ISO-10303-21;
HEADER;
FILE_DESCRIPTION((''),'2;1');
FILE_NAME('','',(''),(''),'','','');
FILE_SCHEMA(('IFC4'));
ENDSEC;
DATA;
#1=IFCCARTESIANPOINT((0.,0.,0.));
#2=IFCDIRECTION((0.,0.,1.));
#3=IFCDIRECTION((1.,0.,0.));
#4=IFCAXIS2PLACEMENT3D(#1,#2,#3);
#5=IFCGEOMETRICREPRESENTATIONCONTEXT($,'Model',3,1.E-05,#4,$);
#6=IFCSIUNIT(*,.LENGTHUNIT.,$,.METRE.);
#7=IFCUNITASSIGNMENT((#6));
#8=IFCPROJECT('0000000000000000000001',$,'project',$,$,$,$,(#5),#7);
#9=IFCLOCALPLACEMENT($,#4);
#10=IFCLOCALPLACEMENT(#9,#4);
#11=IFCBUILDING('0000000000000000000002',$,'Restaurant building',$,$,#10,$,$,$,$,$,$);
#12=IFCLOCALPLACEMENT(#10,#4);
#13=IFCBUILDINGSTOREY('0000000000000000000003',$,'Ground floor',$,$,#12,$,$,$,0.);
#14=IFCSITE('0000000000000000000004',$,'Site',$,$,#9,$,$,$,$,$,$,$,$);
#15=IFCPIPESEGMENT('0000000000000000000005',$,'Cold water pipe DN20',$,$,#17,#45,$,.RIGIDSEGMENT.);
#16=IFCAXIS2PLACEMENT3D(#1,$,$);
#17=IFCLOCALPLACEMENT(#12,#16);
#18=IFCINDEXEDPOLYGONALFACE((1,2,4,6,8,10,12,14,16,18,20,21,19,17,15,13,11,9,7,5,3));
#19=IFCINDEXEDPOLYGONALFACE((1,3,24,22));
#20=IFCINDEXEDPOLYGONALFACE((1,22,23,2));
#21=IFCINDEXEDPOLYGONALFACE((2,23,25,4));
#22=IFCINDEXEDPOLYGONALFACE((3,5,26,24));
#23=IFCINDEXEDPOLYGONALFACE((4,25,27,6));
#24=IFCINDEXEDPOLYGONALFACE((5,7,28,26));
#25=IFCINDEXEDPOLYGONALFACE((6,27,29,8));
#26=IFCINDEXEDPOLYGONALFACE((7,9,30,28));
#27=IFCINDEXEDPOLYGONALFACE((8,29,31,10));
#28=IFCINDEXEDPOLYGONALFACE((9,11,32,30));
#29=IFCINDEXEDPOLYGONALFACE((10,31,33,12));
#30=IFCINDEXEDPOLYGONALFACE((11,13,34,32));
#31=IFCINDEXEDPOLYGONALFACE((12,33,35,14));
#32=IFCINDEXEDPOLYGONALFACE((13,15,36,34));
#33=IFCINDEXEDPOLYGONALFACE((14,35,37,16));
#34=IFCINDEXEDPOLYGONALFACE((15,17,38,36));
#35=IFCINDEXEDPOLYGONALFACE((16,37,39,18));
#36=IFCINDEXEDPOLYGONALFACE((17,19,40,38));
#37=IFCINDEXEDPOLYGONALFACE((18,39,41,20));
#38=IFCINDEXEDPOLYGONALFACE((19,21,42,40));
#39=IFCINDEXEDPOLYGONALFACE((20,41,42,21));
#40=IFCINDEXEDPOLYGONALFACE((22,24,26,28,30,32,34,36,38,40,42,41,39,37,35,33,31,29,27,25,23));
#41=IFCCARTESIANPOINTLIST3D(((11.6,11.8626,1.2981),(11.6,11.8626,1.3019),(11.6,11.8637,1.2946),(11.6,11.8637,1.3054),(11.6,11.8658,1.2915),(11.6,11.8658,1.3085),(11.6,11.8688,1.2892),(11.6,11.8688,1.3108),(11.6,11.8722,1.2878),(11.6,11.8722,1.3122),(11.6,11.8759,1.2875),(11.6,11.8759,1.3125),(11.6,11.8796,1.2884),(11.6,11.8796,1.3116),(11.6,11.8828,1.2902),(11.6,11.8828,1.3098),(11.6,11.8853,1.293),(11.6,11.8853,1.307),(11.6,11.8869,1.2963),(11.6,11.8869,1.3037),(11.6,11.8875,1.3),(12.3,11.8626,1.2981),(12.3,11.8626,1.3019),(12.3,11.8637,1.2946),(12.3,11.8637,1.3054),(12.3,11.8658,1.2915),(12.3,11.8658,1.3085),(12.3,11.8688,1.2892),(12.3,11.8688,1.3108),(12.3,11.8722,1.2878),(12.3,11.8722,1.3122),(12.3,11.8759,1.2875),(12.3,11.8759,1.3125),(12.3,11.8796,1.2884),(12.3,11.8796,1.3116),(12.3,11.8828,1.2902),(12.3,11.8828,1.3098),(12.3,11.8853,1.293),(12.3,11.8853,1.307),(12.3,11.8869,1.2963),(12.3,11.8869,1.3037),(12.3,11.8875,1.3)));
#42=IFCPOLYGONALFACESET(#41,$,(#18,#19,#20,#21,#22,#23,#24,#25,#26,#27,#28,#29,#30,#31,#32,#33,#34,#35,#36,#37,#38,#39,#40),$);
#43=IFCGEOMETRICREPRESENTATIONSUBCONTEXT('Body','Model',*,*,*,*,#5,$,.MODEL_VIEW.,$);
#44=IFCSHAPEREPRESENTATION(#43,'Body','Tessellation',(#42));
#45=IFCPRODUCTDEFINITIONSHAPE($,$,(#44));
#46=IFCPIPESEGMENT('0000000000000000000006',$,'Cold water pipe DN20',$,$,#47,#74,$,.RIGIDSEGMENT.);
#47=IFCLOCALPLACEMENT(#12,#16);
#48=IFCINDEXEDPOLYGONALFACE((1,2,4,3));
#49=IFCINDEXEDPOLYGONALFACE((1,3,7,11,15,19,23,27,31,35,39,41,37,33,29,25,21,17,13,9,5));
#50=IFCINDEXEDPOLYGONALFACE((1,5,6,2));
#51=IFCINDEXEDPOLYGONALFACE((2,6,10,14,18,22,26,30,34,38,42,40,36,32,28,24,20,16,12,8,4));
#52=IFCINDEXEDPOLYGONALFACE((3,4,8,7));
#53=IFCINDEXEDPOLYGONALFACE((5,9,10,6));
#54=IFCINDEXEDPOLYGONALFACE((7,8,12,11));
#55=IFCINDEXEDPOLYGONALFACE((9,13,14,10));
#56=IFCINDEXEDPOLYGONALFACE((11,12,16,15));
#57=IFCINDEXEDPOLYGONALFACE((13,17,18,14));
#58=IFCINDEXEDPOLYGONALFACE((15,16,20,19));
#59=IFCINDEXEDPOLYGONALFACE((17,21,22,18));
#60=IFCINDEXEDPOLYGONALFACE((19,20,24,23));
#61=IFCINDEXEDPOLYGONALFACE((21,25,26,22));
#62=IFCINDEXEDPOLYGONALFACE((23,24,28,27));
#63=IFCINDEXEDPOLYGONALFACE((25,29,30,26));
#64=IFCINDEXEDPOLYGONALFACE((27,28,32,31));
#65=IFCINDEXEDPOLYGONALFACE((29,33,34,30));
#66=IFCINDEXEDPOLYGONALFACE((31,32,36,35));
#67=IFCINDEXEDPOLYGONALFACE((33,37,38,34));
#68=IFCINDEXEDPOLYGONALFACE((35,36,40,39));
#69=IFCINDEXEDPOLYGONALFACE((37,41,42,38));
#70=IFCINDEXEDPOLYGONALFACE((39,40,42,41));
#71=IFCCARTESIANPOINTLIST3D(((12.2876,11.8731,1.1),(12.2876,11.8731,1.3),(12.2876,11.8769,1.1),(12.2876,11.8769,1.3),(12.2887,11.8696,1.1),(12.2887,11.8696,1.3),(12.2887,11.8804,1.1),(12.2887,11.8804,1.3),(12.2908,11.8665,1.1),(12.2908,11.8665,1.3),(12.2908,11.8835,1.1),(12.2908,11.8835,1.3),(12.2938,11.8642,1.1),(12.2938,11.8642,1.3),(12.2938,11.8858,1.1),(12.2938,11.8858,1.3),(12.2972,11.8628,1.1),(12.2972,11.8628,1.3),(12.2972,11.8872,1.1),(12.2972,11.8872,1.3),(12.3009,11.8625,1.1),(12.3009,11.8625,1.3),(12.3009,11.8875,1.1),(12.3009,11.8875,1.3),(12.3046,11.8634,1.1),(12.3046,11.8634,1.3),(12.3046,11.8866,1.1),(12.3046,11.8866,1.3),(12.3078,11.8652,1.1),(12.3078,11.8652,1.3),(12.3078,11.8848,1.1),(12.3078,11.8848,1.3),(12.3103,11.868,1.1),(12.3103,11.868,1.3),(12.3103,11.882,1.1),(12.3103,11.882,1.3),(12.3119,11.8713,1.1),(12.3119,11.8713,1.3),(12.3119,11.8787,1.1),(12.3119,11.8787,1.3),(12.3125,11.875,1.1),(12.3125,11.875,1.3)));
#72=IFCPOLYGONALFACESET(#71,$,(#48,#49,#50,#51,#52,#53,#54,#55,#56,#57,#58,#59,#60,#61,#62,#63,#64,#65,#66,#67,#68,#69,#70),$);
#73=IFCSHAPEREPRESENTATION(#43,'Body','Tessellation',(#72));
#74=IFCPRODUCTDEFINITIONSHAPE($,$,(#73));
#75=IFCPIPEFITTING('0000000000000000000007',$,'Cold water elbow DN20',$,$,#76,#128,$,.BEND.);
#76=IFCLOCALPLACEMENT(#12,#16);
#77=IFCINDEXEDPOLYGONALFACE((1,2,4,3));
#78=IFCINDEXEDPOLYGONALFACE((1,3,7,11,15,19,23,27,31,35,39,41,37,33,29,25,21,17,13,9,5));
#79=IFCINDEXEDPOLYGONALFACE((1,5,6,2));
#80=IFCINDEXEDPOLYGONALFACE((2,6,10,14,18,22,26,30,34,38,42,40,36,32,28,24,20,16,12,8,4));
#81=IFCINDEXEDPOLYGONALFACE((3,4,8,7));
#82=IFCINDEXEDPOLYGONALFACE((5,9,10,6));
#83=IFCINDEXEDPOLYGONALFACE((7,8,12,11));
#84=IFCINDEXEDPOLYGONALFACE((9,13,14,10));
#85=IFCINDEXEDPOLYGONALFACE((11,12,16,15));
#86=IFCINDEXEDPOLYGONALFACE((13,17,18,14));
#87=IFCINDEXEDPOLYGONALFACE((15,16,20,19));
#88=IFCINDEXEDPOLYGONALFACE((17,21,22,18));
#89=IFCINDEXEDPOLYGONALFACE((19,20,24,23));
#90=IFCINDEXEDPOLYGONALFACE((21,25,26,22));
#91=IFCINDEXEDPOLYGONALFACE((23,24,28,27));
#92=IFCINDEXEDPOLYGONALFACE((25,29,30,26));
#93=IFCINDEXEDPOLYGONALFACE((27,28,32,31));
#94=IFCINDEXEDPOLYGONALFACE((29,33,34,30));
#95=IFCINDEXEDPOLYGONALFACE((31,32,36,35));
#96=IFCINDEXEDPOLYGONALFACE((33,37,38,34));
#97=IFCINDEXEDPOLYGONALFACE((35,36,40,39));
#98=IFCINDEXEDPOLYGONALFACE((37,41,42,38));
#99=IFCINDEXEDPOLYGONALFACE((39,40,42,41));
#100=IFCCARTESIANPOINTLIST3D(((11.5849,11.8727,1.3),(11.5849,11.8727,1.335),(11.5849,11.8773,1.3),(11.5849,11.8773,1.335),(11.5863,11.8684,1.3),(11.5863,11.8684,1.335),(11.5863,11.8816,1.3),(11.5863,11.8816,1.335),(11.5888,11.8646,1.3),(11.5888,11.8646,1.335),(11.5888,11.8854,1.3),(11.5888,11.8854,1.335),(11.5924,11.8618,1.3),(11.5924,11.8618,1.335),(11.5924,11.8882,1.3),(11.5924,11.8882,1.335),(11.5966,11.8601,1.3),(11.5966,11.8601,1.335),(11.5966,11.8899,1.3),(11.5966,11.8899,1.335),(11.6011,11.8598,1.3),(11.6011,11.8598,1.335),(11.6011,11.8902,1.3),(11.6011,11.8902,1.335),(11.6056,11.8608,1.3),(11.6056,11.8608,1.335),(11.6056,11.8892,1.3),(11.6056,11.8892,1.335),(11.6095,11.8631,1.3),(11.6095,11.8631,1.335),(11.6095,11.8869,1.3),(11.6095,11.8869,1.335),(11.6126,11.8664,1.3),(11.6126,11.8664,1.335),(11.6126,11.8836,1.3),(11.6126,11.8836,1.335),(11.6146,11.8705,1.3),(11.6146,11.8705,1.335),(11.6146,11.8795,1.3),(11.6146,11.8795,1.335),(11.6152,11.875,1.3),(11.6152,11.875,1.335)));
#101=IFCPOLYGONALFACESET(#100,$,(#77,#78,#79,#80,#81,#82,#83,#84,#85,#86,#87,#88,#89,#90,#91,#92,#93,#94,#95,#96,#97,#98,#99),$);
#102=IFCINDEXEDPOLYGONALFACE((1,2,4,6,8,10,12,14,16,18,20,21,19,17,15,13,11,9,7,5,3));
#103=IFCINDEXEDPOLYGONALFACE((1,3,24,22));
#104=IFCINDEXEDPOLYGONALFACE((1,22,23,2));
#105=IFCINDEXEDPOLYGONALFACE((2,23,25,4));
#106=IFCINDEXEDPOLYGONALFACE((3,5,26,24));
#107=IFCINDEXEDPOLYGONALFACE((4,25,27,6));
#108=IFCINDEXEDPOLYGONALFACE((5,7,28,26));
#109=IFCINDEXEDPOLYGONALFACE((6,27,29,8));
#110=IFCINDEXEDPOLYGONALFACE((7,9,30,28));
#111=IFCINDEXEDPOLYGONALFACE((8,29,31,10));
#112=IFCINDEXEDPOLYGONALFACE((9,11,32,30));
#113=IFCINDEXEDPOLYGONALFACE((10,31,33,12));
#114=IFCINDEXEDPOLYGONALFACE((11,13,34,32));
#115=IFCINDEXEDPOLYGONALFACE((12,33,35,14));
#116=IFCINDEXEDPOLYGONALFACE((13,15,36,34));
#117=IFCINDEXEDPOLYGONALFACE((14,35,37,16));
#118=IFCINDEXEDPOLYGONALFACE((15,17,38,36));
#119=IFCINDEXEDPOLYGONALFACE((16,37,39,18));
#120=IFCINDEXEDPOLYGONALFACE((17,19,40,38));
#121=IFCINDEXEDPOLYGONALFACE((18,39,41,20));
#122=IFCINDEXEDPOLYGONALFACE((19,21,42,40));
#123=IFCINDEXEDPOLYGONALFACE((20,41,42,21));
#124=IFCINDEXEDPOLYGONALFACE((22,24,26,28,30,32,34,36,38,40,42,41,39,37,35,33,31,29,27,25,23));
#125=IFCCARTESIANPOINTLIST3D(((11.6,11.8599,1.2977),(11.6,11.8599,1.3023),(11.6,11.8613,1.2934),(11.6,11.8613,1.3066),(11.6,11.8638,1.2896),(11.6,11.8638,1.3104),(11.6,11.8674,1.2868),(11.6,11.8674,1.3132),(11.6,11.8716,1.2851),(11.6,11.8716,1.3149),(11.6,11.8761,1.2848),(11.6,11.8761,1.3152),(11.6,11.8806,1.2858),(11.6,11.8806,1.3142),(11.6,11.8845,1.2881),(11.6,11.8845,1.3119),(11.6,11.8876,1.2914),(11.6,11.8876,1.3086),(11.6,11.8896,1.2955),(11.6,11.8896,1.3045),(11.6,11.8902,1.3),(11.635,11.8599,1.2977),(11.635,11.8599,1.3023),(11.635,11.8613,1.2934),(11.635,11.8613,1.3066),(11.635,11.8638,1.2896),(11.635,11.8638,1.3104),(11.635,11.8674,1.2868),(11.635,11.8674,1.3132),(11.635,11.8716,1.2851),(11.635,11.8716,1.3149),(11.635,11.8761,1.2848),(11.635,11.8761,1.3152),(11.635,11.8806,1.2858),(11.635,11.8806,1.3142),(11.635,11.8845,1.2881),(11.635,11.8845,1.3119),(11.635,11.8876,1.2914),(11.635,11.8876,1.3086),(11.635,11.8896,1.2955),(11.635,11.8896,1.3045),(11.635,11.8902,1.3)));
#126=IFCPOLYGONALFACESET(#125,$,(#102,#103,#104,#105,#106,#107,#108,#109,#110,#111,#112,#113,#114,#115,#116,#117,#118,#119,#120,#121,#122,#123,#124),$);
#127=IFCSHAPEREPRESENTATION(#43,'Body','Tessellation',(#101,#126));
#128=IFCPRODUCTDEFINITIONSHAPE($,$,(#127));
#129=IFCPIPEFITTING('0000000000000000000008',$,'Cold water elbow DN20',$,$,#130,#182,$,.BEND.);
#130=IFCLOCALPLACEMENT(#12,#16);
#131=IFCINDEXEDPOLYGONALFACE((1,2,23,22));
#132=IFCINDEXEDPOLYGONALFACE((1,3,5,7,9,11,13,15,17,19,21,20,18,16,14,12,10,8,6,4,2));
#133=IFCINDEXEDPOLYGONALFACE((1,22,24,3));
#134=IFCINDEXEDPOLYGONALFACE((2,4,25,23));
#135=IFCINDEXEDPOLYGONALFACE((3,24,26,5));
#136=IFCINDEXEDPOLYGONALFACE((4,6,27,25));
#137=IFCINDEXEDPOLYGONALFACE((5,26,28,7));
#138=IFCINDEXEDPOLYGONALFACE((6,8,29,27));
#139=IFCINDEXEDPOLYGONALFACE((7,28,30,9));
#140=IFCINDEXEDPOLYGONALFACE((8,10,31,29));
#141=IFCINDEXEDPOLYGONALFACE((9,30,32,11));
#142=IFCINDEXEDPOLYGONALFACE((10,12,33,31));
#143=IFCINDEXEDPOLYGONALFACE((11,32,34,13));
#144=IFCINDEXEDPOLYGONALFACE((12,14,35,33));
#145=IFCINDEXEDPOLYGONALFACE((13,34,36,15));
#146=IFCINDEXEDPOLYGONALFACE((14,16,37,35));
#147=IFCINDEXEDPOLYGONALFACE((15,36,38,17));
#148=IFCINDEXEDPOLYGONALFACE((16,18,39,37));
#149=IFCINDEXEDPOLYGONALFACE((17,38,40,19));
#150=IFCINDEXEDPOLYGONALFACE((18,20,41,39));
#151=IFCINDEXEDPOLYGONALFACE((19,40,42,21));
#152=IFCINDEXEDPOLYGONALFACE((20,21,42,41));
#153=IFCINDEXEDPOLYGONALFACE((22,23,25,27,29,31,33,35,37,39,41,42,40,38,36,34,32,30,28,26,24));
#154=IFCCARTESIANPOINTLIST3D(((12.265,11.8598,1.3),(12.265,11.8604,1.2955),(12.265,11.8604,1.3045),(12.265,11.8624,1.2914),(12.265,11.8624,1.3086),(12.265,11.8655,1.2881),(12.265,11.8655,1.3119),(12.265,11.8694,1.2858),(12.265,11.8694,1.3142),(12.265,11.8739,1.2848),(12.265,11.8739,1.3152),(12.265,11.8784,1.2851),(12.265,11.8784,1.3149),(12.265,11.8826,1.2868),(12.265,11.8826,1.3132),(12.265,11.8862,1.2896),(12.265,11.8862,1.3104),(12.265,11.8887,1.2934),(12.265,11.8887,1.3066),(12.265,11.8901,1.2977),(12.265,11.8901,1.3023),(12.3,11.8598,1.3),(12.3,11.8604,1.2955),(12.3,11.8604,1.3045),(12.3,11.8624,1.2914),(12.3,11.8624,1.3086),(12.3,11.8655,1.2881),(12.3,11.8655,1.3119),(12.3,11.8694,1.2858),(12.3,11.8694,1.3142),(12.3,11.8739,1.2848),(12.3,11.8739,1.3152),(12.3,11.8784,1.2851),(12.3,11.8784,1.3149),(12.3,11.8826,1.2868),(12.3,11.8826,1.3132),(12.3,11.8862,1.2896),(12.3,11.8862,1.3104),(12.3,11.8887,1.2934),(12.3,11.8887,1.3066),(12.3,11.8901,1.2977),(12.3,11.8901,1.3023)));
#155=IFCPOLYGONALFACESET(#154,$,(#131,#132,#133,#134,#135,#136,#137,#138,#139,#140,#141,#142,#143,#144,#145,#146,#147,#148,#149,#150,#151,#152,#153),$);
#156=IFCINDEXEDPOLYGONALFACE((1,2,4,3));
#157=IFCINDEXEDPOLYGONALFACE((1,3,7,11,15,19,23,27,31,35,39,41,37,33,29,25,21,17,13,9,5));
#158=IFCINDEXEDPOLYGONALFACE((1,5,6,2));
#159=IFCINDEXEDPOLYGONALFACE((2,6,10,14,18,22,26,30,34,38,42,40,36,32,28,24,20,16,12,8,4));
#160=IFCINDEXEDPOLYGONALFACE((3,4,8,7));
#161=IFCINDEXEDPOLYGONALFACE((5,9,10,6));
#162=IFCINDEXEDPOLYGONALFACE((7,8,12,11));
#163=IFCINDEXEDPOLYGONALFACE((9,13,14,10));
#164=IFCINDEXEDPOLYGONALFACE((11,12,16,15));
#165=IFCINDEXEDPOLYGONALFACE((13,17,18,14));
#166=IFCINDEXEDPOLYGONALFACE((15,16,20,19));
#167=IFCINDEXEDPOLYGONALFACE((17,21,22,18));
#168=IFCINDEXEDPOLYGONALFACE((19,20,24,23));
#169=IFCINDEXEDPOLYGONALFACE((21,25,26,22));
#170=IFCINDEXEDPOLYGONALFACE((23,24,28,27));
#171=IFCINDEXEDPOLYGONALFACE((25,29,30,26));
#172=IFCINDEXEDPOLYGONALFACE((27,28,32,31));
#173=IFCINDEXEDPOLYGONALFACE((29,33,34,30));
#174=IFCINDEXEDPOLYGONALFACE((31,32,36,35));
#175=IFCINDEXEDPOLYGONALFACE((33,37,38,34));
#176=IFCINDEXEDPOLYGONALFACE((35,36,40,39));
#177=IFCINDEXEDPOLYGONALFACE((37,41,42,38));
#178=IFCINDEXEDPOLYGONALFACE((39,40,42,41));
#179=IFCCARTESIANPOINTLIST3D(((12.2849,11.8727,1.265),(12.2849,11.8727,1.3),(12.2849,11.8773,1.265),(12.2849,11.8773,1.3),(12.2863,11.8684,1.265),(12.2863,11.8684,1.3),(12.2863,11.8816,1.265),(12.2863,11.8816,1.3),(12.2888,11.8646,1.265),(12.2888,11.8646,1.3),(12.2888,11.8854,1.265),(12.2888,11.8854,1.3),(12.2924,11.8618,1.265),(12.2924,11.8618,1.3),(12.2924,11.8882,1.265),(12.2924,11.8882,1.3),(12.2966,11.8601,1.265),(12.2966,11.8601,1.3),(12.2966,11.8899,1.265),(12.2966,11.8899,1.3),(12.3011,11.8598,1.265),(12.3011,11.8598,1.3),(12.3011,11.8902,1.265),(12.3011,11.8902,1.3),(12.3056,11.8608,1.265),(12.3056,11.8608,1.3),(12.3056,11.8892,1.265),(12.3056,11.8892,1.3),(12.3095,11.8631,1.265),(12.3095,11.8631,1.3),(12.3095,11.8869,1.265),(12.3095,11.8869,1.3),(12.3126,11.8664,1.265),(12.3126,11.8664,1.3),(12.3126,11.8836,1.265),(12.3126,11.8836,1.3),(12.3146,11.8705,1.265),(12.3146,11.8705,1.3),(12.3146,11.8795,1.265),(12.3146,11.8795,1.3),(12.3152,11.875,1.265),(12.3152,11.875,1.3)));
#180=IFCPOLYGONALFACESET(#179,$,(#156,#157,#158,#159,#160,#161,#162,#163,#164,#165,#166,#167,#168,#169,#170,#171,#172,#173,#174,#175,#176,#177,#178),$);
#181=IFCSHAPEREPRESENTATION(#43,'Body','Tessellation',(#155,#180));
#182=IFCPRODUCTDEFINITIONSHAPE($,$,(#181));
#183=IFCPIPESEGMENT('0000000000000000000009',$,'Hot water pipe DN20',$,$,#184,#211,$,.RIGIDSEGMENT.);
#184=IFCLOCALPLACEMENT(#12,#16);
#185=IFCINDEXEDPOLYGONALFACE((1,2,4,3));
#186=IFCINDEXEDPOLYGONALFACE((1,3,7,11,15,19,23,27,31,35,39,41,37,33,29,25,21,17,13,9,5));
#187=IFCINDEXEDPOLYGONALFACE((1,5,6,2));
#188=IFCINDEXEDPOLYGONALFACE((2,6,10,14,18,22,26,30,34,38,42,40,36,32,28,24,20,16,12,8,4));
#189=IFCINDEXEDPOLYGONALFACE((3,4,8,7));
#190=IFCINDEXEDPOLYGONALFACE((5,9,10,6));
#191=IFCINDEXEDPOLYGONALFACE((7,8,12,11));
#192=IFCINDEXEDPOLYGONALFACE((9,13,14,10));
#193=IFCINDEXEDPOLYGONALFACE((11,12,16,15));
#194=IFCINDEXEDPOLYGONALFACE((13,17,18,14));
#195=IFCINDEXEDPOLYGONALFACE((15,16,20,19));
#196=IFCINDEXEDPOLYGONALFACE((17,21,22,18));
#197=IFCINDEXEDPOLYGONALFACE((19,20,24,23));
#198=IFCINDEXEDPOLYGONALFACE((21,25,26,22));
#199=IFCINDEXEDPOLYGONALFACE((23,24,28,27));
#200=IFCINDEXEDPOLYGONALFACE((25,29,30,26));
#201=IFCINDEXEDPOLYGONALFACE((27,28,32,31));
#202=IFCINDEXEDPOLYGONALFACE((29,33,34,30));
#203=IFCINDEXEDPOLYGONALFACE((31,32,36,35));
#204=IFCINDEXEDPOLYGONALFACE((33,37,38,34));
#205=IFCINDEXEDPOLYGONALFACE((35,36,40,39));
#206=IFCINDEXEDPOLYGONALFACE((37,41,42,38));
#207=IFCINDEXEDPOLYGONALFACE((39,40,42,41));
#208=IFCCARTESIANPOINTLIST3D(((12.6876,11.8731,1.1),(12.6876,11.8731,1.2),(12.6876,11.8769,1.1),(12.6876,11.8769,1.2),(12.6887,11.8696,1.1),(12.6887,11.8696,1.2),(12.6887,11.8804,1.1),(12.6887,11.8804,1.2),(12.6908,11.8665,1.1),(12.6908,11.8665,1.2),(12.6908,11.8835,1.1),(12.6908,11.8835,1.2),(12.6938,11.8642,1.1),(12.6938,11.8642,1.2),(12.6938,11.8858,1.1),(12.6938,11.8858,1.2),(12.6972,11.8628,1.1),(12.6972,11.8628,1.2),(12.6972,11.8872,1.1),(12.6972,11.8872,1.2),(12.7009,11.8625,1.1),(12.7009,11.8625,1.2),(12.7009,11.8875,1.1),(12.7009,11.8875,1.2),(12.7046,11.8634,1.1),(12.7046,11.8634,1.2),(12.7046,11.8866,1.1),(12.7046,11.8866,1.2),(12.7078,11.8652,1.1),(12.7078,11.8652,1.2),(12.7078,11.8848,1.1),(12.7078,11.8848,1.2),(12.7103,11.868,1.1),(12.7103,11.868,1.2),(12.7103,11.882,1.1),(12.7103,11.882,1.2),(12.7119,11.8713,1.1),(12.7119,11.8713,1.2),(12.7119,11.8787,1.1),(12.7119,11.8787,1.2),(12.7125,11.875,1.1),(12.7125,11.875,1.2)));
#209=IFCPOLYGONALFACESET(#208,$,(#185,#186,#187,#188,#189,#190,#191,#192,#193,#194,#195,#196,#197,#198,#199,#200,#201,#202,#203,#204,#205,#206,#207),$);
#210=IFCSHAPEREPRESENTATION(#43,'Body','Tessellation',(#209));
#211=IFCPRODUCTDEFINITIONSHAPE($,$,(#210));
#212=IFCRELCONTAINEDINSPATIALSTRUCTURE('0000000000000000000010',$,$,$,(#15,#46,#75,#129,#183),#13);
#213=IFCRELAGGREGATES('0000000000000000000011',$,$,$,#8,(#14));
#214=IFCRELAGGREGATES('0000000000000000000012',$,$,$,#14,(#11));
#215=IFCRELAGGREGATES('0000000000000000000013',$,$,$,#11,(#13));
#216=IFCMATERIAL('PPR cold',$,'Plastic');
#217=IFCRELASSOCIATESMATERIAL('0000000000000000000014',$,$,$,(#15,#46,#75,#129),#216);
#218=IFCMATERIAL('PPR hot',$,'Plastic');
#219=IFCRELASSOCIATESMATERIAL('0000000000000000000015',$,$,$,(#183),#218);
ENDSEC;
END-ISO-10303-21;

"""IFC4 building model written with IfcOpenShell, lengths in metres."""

from ifc_helpers import new_model, si_unit, frame, origin, origin_with_axes, origin_2d, place, context, subcontext, project, spatial, circle, extrude, material, element, save


model = new_model("IFC4")

# Units and contexts
model_context = context("Model", 3, precision=1e-05, world=origin_with_axes())
body_context = subcontext(model_context, "Body", "Model", "MODEL_VIEW")
ifc_project = project(units=[si_unit("LENGTHUNIT", "METRE")], contexts=[model_context])

# Site, building, storey
site_placement = place(None, origin_with_axes())
site = spatial("IfcSite", under=ifc_project, at=site_placement, Name="Site")
building_placement = place(site_placement, origin_with_axes())
building = spatial("IfcBuilding", under=site, at=building_placement, Name="Restaurant building")
storey_placement = place(building_placement, origin_with_axes())
storey = spatial("IfcBuildingStorey", under=building, at=storey_placement, Name="Ground floor", Elevation=0.0)

# Pipe segments
ifc_material_1 = material(Name="PPR cold", Category="Plastic")
pipe_segment_1_placement = place(storey_placement, frame((11.6, 11.875, 1.3)))
element("IfcPipeSegment", 1, at=pipe_segment_1_placement, inside=storey, material=ifc_material_1, Name="Cold water pipe DN20", PredefinedType="RIGIDSEGMENT", context=body_context, shape_type="SweptSolid", body=[
    extrude(circle(Radius=0.0125, at=origin_2d()), frame((0.0, 0.0, 0.0), z_axis=(1.0, 0.0, 0.0), x_axis=(0.0, 1.0, 0.0)), (0.0, 0.0, 1.0), 0.7),
])
pipe_segment_2_placement = place(storey_placement, frame((12.3, 11.875, 1.3)))
element("IfcPipeSegment", 2, at=pipe_segment_2_placement, inside=storey, material=ifc_material_1, Name="Cold water pipe DN20", PredefinedType="RIGIDSEGMENT", context=body_context, shape_type="SweptSolid", body=[
    extrude(circle(Radius=0.0125, at=origin_2d()), frame((0.0, 0.0, 0.0), z_axis=(0.0, 0.0, -1.0), x_axis=(1.0, 0.0, 0.0)), (0.0, 0.0, 1.0), 0.2),
])

# Pipe fittings
pipe_fitting_1_placement = place(storey_placement, frame((11.6, 11.875, 1.3)))
element("IfcPipeFitting", 3, at=pipe_fitting_1_placement, inside=storey, material=ifc_material_1, Name="Cold water elbow DN20", PredefinedType="BEND", context=body_context, shape_type="SweptSolid", body=[
    extrude(circle(Radius=0.0152, at=origin_2d()), origin(), (0.0, 0.0, 1.0), 0.035),
    extrude(circle(Radius=0.0152, at=origin_2d()), frame((0.0, 0.0, 0.0), z_axis=(1.0, 0.0, 0.0), x_axis=(0.0, 1.0, 0.0)), (0.0, 0.0, 1.0), 0.035),
])
pipe_fitting_2_placement = place(storey_placement, frame((12.3, 11.875, 1.3)))
element("IfcPipeFitting", 4, at=pipe_fitting_2_placement, inside=storey, material=ifc_material_1, Name="Cold water elbow DN20", PredefinedType="BEND", context=body_context, shape_type="SweptSolid", body=[
    extrude(circle(Radius=0.0152, at=origin_2d()), frame((0.0, 0.0, 0.0), z_axis=(-1.0, 0.0, 0.0), x_axis=(0.0, -1.0, 0.0)), (0.0, 0.0, 1.0), 0.035),
    extrude(circle(Radius=0.0152, at=origin_2d()), frame((0.0, 0.0, 0.0), z_axis=(0.0, 0.0, -1.0), x_axis=(1.0, 0.0, 0.0)), (0.0, 0.0, 1.0), 0.035),
])

# Pipe segment
ifc_material_2 = material(Name="PPR hot", Category="Plastic")
pipe_segment_3_placement = place(storey_placement, frame((12.7, 11.875, 1.2)))
element("IfcPipeSegment", 5, at=pipe_segment_3_placement, inside=storey, material=ifc_material_2, Name="Hot water pipe DN20", PredefinedType="RIGIDSEGMENT", context=body_context, shape_type="SweptSolid", body=[
    extrude(circle(Radius=0.0125, at=origin_2d()), frame((0.0, 0.0, 0.0), z_axis=(0.0, 0.0, -1.0), x_axis=(1.0, 0.0, 0.0)), (0.0, 0.0, 1.0), 0.1),
])

save(model, "model.ifc")
